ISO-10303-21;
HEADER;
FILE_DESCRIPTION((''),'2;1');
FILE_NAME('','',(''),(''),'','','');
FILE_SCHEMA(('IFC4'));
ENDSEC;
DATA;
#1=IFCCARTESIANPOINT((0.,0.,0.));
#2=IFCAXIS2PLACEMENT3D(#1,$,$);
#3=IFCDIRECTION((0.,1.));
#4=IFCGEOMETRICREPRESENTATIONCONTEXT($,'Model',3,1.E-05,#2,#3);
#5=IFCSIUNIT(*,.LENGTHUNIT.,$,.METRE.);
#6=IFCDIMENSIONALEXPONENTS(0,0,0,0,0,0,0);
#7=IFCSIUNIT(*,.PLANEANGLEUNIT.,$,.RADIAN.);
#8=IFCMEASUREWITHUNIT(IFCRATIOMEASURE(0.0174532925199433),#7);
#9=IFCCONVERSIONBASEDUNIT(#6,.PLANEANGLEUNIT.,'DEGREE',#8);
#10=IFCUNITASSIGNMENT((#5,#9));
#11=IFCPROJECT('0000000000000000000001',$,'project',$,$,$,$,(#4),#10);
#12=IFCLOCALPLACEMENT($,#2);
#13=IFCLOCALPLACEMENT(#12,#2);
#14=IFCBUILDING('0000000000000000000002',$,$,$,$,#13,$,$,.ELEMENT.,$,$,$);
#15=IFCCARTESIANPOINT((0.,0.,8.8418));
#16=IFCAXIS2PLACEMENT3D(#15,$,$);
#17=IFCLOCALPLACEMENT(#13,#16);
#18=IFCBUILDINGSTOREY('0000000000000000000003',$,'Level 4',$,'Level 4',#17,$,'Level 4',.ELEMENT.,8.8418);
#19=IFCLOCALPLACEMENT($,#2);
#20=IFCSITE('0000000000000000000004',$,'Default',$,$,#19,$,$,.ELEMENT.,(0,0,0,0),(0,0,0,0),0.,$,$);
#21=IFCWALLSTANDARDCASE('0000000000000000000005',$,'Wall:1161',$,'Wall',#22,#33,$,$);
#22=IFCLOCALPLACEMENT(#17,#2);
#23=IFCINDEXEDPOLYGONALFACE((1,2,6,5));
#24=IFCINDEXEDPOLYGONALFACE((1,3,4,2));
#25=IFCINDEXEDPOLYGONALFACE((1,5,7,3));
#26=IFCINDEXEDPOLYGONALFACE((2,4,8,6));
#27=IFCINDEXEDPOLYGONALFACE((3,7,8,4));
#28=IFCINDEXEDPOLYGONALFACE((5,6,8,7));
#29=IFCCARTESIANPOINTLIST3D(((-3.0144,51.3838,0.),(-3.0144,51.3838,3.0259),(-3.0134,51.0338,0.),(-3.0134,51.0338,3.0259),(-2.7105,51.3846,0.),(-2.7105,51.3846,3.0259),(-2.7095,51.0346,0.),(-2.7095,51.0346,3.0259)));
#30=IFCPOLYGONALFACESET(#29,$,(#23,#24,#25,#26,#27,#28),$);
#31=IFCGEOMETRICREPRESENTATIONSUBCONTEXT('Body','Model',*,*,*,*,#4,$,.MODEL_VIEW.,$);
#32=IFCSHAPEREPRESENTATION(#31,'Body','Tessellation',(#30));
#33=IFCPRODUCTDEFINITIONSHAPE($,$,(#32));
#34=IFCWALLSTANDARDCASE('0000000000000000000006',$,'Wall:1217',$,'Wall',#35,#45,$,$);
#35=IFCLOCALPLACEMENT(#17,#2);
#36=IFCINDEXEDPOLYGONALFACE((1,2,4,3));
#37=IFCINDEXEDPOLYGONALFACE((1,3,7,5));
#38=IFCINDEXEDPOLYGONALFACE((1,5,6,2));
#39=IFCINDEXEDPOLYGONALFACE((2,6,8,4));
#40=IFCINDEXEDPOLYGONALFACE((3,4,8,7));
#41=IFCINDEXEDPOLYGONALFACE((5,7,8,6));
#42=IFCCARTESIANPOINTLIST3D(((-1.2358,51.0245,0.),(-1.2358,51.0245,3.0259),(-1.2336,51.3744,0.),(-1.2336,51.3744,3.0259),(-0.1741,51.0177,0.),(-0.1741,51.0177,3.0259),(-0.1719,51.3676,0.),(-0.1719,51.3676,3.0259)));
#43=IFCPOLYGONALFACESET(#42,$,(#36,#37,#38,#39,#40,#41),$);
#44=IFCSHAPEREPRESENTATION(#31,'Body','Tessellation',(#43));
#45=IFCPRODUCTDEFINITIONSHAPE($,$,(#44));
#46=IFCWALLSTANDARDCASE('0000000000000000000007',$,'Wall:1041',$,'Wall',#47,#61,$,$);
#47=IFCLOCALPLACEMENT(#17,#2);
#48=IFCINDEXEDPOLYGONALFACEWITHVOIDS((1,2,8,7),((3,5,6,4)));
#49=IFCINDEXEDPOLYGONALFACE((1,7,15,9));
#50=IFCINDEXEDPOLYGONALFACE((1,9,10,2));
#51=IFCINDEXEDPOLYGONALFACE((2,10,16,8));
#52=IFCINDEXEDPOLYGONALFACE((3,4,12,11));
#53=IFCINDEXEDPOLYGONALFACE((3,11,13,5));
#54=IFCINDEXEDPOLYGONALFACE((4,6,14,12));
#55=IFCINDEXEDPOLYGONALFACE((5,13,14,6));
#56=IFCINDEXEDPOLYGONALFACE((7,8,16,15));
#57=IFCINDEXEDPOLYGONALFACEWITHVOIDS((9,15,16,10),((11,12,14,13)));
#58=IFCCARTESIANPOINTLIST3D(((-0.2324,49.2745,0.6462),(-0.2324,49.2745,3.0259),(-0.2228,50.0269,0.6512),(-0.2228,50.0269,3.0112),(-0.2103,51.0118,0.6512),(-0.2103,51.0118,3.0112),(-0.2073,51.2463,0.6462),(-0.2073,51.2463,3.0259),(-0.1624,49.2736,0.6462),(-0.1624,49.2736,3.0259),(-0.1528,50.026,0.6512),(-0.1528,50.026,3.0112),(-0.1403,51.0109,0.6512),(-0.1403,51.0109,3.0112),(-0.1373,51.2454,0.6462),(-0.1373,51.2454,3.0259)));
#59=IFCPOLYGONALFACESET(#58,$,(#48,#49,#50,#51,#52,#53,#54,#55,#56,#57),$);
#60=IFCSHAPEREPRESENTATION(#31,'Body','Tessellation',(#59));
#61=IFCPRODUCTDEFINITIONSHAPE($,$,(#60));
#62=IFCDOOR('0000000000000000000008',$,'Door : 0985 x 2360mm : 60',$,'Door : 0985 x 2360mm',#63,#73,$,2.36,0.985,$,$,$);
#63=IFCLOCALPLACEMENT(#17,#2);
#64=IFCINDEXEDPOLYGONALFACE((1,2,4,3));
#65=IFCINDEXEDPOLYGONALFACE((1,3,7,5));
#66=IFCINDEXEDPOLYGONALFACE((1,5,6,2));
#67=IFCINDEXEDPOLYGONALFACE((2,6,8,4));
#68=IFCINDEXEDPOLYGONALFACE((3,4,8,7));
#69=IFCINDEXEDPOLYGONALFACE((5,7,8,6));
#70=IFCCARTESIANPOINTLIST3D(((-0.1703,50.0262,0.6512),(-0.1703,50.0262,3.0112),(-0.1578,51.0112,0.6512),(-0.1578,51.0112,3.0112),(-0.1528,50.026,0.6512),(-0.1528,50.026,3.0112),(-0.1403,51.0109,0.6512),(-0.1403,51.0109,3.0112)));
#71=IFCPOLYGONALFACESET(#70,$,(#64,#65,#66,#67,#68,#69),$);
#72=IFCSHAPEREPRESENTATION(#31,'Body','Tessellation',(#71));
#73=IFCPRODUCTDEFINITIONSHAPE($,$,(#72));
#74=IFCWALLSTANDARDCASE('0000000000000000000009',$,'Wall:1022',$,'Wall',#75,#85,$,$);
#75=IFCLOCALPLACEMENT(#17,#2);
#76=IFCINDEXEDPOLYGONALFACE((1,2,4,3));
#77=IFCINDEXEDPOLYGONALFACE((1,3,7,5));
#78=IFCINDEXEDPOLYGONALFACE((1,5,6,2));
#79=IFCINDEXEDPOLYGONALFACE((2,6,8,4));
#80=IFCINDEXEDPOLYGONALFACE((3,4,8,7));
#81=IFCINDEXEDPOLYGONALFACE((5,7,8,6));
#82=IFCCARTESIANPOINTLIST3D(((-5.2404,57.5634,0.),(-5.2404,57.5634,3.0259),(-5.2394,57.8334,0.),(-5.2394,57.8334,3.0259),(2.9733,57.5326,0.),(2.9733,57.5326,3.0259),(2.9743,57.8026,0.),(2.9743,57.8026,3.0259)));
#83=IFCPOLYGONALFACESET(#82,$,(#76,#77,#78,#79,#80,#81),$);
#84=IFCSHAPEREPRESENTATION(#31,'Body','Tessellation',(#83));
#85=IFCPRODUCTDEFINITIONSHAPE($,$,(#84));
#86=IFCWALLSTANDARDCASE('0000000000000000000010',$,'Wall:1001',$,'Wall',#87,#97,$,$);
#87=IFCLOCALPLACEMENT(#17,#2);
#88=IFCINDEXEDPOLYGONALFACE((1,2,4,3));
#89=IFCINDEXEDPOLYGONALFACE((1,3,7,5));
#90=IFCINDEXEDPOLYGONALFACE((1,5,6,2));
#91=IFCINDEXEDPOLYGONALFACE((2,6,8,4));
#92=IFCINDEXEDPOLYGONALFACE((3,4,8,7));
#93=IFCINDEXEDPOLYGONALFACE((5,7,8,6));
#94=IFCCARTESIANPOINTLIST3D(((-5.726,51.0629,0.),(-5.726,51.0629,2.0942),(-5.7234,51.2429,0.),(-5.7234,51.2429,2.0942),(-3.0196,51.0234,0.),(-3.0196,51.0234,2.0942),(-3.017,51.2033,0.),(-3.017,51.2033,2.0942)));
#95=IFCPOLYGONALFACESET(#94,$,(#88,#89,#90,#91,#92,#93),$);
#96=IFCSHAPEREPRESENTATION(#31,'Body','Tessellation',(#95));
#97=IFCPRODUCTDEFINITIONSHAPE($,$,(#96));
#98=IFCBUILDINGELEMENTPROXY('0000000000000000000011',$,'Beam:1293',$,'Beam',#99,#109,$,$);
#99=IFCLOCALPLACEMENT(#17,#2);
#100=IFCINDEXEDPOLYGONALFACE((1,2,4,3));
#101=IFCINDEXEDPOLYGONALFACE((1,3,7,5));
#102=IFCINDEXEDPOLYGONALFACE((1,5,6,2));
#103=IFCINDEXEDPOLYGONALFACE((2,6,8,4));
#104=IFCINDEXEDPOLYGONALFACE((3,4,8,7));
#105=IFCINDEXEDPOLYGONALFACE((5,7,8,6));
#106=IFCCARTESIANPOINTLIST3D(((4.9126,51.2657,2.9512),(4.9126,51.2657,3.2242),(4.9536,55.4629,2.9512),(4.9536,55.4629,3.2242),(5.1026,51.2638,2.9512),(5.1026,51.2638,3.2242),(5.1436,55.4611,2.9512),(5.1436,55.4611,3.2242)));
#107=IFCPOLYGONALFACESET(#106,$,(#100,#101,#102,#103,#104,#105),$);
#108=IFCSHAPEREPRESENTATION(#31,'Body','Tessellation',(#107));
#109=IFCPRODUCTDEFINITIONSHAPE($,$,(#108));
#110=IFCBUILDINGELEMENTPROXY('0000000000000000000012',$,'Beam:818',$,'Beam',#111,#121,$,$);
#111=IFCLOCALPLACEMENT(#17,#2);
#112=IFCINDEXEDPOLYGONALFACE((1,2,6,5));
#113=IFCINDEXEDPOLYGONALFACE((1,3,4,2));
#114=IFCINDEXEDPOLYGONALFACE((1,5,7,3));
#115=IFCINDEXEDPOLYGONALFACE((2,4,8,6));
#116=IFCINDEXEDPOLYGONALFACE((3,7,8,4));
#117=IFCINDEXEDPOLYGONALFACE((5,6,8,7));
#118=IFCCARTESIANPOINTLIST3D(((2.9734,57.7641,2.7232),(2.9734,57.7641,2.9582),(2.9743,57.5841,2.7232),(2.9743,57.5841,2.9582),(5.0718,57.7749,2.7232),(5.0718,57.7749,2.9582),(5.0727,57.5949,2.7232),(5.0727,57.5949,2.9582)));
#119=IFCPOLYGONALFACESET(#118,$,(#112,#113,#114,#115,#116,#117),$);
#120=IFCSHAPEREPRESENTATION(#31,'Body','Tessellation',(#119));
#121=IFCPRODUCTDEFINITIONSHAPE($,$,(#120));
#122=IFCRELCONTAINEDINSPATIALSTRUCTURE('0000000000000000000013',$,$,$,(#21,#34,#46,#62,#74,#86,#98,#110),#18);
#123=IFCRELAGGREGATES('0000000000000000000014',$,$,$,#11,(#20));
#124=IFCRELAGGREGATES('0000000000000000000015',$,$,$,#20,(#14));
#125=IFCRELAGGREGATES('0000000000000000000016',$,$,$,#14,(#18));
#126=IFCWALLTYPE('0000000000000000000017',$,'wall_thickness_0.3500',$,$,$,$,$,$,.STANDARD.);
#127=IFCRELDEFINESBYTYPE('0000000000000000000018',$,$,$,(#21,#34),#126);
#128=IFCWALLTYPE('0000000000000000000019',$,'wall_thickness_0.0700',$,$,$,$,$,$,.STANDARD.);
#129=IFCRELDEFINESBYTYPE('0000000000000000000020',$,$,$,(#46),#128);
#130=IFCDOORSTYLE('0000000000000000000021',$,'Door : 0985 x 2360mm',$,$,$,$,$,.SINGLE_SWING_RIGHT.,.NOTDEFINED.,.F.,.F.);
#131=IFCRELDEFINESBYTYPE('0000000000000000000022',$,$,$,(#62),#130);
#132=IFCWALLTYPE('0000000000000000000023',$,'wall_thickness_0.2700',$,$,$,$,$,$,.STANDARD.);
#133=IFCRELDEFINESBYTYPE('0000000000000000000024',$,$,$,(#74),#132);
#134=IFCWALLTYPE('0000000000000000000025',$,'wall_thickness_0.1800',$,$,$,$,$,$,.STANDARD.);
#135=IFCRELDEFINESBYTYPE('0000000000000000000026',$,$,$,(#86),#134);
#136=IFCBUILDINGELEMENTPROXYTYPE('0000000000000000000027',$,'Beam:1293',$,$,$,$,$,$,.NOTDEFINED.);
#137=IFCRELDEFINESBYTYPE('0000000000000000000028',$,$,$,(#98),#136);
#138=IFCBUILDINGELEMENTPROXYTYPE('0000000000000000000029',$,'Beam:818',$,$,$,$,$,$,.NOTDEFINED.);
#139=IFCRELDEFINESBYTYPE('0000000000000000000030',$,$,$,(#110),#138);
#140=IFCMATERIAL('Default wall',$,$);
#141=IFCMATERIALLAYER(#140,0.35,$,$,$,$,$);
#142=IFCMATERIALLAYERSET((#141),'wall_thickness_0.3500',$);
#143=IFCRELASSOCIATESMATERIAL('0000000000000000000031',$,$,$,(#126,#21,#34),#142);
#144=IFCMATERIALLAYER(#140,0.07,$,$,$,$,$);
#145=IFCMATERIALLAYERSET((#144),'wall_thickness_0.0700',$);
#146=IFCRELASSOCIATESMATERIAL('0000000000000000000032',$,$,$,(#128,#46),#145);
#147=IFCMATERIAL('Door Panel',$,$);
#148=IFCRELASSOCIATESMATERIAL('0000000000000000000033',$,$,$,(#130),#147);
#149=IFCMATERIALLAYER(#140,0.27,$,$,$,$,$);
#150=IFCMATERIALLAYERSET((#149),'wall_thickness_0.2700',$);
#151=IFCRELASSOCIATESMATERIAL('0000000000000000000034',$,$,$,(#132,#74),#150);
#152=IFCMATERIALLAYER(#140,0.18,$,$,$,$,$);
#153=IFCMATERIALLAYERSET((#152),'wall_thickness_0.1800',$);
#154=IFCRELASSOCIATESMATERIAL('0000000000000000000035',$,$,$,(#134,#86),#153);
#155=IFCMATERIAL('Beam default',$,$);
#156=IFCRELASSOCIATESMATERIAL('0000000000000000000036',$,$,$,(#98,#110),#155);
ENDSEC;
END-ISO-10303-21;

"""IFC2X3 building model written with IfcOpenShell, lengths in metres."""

from ifc_helpers import new_model, entity, si_unit, converted_unit, direction, frame, frame_2d, origin, origin_2d_with_axis, place, context, subcontext, project, spatial, polyline, rectangle, outline, extrude, source, transform, mapped, material, layer, layer_set, layer_usage, type_object, type_shapes, element, fill, save


model = new_model("IFC2X3")

# Units and contexts
model_context = context("Model", 3, precision=1e-05, world=origin(), true_north=direction((0.0, 1.0)))
body_context = subcontext(model_context, "Body", "Model", "MODEL_VIEW")
ifc_project = project(units=[si_unit("LENGTHUNIT", "METRE"), converted_unit("PLANEANGLEUNIT", "DEGREE", entity("IfcRatioMeasure", 0.0174532925199433), si_unit("PLANEANGLEUNIT", "RADIAN"), dimensions=[0, 0, 0, 0, 0, 0, 0])], contexts=[model_context])

# Site, building, storey
site_placement = place(None, origin())
site = spatial("IfcSite", under=ifc_project, at=site_placement, Name="Default", CompositionType="ELEMENT", RefLatitude=(0, 0, 0, 0), RefLongitude=(0, 0, 0, 0), RefElevation=0.0)
placement_1 = place(None, origin())
building_placement = place(placement_1, origin())
building = spatial("IfcBuilding", under=site, at=building_placement, CompositionType="ELEMENT")
storey_placement = place(building_placement, frame((0.0, 0.0, 8.8418)))
storey = spatial("IfcBuildingStorey", under=building, at=storey_placement, Name="Level 4", ObjectType="Level 4", LongName="Level 4", CompositionType="ELEMENT", Elevation=8.8418)

# Shared definitions
ifc_material_1 = material(Name="Default wall")

# Shared definitions
ifc_material_2 = material(Name="Door Panel")

# Walls
ifc_layer_1 = layer(ifc_material_1, 0.35)
ifc_layer_set_1 = layer_set([ifc_layer_1], Name="wall_thickness_0.3500")
ifc_layer_usage_1 = layer_usage(ifc_layer_set_1, "AXIS2", "POSITIVE", -0.175)
wall_type_1 = type_object("IfcWallType", Name="wall_thickness_0.3500", PredefinedType="STANDARD", material=ifc_layer_set_1)
wall_1_placement = place(storey_placement, frame((-2.71, 51.2096, 0.0), z_axis=(0.0, 0.0, 1.0), x_axis=(-0.999996, -0.002724, 0.0)))
element("IfcWallStandardCase", 1, at=wall_1_placement, inside=storey, type_object=wall_type_1, material=ifc_layer_usage_1, Name="Wall:1161", ObjectType="Wall", context=body_context, shape_type="SweptSolid", body=[
    extrude(outline(polyline([(0.3039, -0.175), (0.3039, 0.175), (0.0, 0.175), (0.0, -0.175), (0.3039, -0.175)])), origin(), (0.0, 0.0, 1.0), 3.0259),
])
wall_2_placement = place(storey_placement, frame((-1.2347, 51.1994, 0.0), z_axis=(0.0, 0.0, 1.0), x_axis=(0.99998, -0.006399, 0.0)))
element("IfcWallStandardCase", 2, at=wall_2_placement, inside=storey, type_object=wall_type_1, material=ifc_layer_usage_1, Name="Wall:1217", ObjectType="Wall", context=body_context, shape_type="SweptSolid", body=[
    extrude(outline(polyline([(1.0617, -0.175), (1.0617, 0.175), (0.0, 0.175), (0.0, -0.175), (1.0617, -0.175)])), origin(), (0.0, 0.0, 1.0), 3.0259),
])

# Wall, opening, door
ifc_layer_2 = layer(ifc_material_1, 0.07)
ifc_layer_set_2 = layer_set([ifc_layer_2], Name="wall_thickness_0.0700")
ifc_layer_usage_2 = layer_usage(ifc_layer_set_2, "AXIS2", "POSITIVE", -0.035)
wall_type_2 = type_object("IfcWallType", Name="wall_thickness_0.0700", PredefinedType="STANDARD", material=ifc_layer_set_2)
placement_2 = place(building_placement, frame((0.0, 0.0, 9.488)))
wall_3_placement = place(placement_2, frame((-0.1723, 51.2458, 0.0), z_axis=(0.0, 0.0, 1.0), x_axis=(-0.012708, -0.999919, 0.0)))
wall_3 = element("IfcWallStandardCase", 3, at=wall_3_placement, inside=storey, type_object=wall_type_2, material=ifc_layer_usage_2, Name="Wall:1041", ObjectType="Wall", context=body_context, shape_type="SweptSolid", body=[
    extrude(outline(polyline([(1.9719, -0.035), (1.9719, 0.035), (0.0, 0.035), (0.0, -0.035), (1.9719, -0.035)])), origin(), (0.0, 0.0, 1.0), 2.3797),
])
opening_1_placement = place(wall_3_placement, frame((0.2345, -0.035, 0.005)))
opening_1 = element("IfcOpeningElement", 4, at=opening_1_placement, cuts=wall_3, ObjectType="Opening", context=body_context, shape_type="SweptSolid", body=[
    extrude(rectangle(XDim=0.985, YDim=2.36, at=frame_2d((1.18, 0.4925), x_axis=(0.0, 1.0))), frame((0.0, 0.0, 0.0), z_axis=(0.0, 1.0, 0.0), x_axis=(0.0, 0.0, 1.0)), (0.0, 0.0, 1.0), 0.07),
])
door_style_1 = type_object("IfcDoorStyle", Name="Door : 0985 x 2360mm", ConstructionType="NOTDEFINED", OperationType="SINGLE_SWING_RIGHT", ParameterTakesPrecedence=False, Sizeable=False, material=ifc_material_2)
shared_shape_1 = source(origin(), body_context, "Body", "SweptSolid", [
    extrude(rectangle(XDim=0.0175, YDim=0.985, at=origin_2d_with_axis()), frame((0.4925, 0.0613, 0.0), z_axis=(0.0, 0.0, 1.0), x_axis=(0.0, 1.0, 0.0)), (0.0, 0.0, 1.0), 2.36),
])
type_shapes(door_style_1, [shared_shape_1])
door_1_placement = place(opening_1_placement, origin())
door_1 = element("IfcDoor", 5, at=door_1_placement, inside=storey, type_object=door_style_1, Name="Door : 0985 x 2360mm : 60", ObjectType="Door : 0985 x 2360mm", OverallHeight=2.36, OverallWidth=0.985, context=body_context, shape_type="MappedRepresentation", body=[
    mapped(shared_shape_1, transform((0.0, 0.0, 0.0), scale=1.0)),
])
fill(opening_1, door_1)

# Walls
ifc_layer_3 = layer(ifc_material_1, 0.27)
ifc_layer_set_3 = layer_set([ifc_layer_3], Name="wall_thickness_0.2700")
ifc_layer_usage_3 = layer_usage(ifc_layer_set_3, "AXIS2", "POSITIVE", -0.135)
wall_type_3 = type_object("IfcWallType", Name="wall_thickness_0.2700", PredefinedType="STANDARD", material=ifc_layer_set_3)
wall_4_placement = place(storey_placement, frame((-5.2399, 57.6984, 0.0), z_axis=(0.0, 0.0, 1.0), x_axis=(0.999993, -0.003758, 0.0)))
element("IfcWallStandardCase", 6, at=wall_4_placement, inside=storey, type_object=wall_type_3, material=ifc_layer_usage_3, Name="Wall:1022", ObjectType="Wall", context=body_context, shape_type="SweptSolid", body=[
    extrude(outline(polyline([(8.2138, -0.135), (8.2138, 0.135), (0.0, 0.135), (0.0, -0.135), (8.2138, -0.135)])), origin(), (0.0, 0.0, 1.0), 3.0259),
])
ifc_layer_4 = layer(ifc_material_1, 0.18)
ifc_layer_set_4 = layer_set([ifc_layer_4], Name="wall_thickness_0.1800")
ifc_layer_usage_4 = layer_usage(ifc_layer_set_4, "AXIS2", "POSITIVE", -0.09)
wall_type_4 = type_object("IfcWallType", Name="wall_thickness_0.1800", PredefinedType="STANDARD", material=ifc_layer_set_4)
wall_5_placement = place(storey_placement, frame((-5.7247, 51.1529, 0.0), z_axis=(0.0, 0.0, 1.0), x_axis=(0.999893, -0.014612, 0.0)))
element("IfcWallStandardCase", 7, at=wall_5_placement, inside=storey, type_object=wall_type_4, material=ifc_layer_usage_4, Name="Wall:1001", ObjectType="Wall", context=body_context, shape_type="SweptSolid", body=[
    extrude(outline(polyline([(2.7067, -0.09), (2.7067, 0.09), (0.0, 0.09), (0.0, -0.09), (2.7067, -0.09)])), origin(), (0.0, 0.0, 1.0), 2.0942),
])

# Building element proxies
ifc_material_3 = material(Name="Beam default")
building_element_proxy_type_1 = type_object("IfcBuildingElementProxyType", Name="Beam:1293", PredefinedType="NOTDEFINED")
shared_shape_2 = source(origin(), body_context, "Body", "SweptSolid", [
    extrude(outline(polyline([(4.1974, -0.095), (4.1974, 0.095), (0.0, 0.095), (0.0, -0.095), (4.1974, -0.095)])), origin(), (0.0, 0.0, 1.0), 0.273),
])
type_shapes(building_element_proxy_type_1, [shared_shape_2])
placement_3 = place(building_placement, frame((0.0, 0.0, 11.793)))
proxy_1_placement = place(placement_3, frame((5.0486, 55.462, 0.0), z_axis=(0.0, 0.0, 1.0), x_axis=(-0.009771, -0.999952, 0.0)))
element("IfcBuildingElementProxy", 8, at=proxy_1_placement, inside=storey, type_object=building_element_proxy_type_1, material=ifc_material_3, Name="Beam:1293", ObjectType="Beam", context=body_context, shape_type="MappedRepresentation", body=[
    mapped(shared_shape_2, transform((0.0, 0.0, 0.0), scale=1.0)),
])
building_element_proxy_type_2 = type_object("IfcBuildingElementProxyType", Name="Beam:818", PredefinedType="NOTDEFINED")
shared_shape_3 = source(origin(), body_context, "Body", "SweptSolid", [
    extrude(outline(polyline([(2.0985, -0.09), (2.0985, 0.09), (0.0, 0.09), (0.0, -0.09), (2.0985, -0.09)])), origin(), (0.0, 0.0, 1.0), 0.235),
])
type_shapes(building_element_proxy_type_2, [shared_shape_3])
placement_4 = place(building_placement, frame((0.0, 0.0, 11.565)))
proxy_2_placement = place(placement_4, frame((2.9738, 57.6741, 0.0), z_axis=(0.0, 0.0, 1.0), x_axis=(0.999987, 0.005175, 0.0)))
element("IfcBuildingElementProxy", 9, at=proxy_2_placement, inside=storey, type_object=building_element_proxy_type_2, material=ifc_material_3, Name="Beam:818", ObjectType="Beam", context=body_context, shape_type="MappedRepresentation", body=[
    mapped(shared_shape_3, transform((0.0, 0.0, 0.0), scale=1.0)),
])

save(model, "model.ifc")
